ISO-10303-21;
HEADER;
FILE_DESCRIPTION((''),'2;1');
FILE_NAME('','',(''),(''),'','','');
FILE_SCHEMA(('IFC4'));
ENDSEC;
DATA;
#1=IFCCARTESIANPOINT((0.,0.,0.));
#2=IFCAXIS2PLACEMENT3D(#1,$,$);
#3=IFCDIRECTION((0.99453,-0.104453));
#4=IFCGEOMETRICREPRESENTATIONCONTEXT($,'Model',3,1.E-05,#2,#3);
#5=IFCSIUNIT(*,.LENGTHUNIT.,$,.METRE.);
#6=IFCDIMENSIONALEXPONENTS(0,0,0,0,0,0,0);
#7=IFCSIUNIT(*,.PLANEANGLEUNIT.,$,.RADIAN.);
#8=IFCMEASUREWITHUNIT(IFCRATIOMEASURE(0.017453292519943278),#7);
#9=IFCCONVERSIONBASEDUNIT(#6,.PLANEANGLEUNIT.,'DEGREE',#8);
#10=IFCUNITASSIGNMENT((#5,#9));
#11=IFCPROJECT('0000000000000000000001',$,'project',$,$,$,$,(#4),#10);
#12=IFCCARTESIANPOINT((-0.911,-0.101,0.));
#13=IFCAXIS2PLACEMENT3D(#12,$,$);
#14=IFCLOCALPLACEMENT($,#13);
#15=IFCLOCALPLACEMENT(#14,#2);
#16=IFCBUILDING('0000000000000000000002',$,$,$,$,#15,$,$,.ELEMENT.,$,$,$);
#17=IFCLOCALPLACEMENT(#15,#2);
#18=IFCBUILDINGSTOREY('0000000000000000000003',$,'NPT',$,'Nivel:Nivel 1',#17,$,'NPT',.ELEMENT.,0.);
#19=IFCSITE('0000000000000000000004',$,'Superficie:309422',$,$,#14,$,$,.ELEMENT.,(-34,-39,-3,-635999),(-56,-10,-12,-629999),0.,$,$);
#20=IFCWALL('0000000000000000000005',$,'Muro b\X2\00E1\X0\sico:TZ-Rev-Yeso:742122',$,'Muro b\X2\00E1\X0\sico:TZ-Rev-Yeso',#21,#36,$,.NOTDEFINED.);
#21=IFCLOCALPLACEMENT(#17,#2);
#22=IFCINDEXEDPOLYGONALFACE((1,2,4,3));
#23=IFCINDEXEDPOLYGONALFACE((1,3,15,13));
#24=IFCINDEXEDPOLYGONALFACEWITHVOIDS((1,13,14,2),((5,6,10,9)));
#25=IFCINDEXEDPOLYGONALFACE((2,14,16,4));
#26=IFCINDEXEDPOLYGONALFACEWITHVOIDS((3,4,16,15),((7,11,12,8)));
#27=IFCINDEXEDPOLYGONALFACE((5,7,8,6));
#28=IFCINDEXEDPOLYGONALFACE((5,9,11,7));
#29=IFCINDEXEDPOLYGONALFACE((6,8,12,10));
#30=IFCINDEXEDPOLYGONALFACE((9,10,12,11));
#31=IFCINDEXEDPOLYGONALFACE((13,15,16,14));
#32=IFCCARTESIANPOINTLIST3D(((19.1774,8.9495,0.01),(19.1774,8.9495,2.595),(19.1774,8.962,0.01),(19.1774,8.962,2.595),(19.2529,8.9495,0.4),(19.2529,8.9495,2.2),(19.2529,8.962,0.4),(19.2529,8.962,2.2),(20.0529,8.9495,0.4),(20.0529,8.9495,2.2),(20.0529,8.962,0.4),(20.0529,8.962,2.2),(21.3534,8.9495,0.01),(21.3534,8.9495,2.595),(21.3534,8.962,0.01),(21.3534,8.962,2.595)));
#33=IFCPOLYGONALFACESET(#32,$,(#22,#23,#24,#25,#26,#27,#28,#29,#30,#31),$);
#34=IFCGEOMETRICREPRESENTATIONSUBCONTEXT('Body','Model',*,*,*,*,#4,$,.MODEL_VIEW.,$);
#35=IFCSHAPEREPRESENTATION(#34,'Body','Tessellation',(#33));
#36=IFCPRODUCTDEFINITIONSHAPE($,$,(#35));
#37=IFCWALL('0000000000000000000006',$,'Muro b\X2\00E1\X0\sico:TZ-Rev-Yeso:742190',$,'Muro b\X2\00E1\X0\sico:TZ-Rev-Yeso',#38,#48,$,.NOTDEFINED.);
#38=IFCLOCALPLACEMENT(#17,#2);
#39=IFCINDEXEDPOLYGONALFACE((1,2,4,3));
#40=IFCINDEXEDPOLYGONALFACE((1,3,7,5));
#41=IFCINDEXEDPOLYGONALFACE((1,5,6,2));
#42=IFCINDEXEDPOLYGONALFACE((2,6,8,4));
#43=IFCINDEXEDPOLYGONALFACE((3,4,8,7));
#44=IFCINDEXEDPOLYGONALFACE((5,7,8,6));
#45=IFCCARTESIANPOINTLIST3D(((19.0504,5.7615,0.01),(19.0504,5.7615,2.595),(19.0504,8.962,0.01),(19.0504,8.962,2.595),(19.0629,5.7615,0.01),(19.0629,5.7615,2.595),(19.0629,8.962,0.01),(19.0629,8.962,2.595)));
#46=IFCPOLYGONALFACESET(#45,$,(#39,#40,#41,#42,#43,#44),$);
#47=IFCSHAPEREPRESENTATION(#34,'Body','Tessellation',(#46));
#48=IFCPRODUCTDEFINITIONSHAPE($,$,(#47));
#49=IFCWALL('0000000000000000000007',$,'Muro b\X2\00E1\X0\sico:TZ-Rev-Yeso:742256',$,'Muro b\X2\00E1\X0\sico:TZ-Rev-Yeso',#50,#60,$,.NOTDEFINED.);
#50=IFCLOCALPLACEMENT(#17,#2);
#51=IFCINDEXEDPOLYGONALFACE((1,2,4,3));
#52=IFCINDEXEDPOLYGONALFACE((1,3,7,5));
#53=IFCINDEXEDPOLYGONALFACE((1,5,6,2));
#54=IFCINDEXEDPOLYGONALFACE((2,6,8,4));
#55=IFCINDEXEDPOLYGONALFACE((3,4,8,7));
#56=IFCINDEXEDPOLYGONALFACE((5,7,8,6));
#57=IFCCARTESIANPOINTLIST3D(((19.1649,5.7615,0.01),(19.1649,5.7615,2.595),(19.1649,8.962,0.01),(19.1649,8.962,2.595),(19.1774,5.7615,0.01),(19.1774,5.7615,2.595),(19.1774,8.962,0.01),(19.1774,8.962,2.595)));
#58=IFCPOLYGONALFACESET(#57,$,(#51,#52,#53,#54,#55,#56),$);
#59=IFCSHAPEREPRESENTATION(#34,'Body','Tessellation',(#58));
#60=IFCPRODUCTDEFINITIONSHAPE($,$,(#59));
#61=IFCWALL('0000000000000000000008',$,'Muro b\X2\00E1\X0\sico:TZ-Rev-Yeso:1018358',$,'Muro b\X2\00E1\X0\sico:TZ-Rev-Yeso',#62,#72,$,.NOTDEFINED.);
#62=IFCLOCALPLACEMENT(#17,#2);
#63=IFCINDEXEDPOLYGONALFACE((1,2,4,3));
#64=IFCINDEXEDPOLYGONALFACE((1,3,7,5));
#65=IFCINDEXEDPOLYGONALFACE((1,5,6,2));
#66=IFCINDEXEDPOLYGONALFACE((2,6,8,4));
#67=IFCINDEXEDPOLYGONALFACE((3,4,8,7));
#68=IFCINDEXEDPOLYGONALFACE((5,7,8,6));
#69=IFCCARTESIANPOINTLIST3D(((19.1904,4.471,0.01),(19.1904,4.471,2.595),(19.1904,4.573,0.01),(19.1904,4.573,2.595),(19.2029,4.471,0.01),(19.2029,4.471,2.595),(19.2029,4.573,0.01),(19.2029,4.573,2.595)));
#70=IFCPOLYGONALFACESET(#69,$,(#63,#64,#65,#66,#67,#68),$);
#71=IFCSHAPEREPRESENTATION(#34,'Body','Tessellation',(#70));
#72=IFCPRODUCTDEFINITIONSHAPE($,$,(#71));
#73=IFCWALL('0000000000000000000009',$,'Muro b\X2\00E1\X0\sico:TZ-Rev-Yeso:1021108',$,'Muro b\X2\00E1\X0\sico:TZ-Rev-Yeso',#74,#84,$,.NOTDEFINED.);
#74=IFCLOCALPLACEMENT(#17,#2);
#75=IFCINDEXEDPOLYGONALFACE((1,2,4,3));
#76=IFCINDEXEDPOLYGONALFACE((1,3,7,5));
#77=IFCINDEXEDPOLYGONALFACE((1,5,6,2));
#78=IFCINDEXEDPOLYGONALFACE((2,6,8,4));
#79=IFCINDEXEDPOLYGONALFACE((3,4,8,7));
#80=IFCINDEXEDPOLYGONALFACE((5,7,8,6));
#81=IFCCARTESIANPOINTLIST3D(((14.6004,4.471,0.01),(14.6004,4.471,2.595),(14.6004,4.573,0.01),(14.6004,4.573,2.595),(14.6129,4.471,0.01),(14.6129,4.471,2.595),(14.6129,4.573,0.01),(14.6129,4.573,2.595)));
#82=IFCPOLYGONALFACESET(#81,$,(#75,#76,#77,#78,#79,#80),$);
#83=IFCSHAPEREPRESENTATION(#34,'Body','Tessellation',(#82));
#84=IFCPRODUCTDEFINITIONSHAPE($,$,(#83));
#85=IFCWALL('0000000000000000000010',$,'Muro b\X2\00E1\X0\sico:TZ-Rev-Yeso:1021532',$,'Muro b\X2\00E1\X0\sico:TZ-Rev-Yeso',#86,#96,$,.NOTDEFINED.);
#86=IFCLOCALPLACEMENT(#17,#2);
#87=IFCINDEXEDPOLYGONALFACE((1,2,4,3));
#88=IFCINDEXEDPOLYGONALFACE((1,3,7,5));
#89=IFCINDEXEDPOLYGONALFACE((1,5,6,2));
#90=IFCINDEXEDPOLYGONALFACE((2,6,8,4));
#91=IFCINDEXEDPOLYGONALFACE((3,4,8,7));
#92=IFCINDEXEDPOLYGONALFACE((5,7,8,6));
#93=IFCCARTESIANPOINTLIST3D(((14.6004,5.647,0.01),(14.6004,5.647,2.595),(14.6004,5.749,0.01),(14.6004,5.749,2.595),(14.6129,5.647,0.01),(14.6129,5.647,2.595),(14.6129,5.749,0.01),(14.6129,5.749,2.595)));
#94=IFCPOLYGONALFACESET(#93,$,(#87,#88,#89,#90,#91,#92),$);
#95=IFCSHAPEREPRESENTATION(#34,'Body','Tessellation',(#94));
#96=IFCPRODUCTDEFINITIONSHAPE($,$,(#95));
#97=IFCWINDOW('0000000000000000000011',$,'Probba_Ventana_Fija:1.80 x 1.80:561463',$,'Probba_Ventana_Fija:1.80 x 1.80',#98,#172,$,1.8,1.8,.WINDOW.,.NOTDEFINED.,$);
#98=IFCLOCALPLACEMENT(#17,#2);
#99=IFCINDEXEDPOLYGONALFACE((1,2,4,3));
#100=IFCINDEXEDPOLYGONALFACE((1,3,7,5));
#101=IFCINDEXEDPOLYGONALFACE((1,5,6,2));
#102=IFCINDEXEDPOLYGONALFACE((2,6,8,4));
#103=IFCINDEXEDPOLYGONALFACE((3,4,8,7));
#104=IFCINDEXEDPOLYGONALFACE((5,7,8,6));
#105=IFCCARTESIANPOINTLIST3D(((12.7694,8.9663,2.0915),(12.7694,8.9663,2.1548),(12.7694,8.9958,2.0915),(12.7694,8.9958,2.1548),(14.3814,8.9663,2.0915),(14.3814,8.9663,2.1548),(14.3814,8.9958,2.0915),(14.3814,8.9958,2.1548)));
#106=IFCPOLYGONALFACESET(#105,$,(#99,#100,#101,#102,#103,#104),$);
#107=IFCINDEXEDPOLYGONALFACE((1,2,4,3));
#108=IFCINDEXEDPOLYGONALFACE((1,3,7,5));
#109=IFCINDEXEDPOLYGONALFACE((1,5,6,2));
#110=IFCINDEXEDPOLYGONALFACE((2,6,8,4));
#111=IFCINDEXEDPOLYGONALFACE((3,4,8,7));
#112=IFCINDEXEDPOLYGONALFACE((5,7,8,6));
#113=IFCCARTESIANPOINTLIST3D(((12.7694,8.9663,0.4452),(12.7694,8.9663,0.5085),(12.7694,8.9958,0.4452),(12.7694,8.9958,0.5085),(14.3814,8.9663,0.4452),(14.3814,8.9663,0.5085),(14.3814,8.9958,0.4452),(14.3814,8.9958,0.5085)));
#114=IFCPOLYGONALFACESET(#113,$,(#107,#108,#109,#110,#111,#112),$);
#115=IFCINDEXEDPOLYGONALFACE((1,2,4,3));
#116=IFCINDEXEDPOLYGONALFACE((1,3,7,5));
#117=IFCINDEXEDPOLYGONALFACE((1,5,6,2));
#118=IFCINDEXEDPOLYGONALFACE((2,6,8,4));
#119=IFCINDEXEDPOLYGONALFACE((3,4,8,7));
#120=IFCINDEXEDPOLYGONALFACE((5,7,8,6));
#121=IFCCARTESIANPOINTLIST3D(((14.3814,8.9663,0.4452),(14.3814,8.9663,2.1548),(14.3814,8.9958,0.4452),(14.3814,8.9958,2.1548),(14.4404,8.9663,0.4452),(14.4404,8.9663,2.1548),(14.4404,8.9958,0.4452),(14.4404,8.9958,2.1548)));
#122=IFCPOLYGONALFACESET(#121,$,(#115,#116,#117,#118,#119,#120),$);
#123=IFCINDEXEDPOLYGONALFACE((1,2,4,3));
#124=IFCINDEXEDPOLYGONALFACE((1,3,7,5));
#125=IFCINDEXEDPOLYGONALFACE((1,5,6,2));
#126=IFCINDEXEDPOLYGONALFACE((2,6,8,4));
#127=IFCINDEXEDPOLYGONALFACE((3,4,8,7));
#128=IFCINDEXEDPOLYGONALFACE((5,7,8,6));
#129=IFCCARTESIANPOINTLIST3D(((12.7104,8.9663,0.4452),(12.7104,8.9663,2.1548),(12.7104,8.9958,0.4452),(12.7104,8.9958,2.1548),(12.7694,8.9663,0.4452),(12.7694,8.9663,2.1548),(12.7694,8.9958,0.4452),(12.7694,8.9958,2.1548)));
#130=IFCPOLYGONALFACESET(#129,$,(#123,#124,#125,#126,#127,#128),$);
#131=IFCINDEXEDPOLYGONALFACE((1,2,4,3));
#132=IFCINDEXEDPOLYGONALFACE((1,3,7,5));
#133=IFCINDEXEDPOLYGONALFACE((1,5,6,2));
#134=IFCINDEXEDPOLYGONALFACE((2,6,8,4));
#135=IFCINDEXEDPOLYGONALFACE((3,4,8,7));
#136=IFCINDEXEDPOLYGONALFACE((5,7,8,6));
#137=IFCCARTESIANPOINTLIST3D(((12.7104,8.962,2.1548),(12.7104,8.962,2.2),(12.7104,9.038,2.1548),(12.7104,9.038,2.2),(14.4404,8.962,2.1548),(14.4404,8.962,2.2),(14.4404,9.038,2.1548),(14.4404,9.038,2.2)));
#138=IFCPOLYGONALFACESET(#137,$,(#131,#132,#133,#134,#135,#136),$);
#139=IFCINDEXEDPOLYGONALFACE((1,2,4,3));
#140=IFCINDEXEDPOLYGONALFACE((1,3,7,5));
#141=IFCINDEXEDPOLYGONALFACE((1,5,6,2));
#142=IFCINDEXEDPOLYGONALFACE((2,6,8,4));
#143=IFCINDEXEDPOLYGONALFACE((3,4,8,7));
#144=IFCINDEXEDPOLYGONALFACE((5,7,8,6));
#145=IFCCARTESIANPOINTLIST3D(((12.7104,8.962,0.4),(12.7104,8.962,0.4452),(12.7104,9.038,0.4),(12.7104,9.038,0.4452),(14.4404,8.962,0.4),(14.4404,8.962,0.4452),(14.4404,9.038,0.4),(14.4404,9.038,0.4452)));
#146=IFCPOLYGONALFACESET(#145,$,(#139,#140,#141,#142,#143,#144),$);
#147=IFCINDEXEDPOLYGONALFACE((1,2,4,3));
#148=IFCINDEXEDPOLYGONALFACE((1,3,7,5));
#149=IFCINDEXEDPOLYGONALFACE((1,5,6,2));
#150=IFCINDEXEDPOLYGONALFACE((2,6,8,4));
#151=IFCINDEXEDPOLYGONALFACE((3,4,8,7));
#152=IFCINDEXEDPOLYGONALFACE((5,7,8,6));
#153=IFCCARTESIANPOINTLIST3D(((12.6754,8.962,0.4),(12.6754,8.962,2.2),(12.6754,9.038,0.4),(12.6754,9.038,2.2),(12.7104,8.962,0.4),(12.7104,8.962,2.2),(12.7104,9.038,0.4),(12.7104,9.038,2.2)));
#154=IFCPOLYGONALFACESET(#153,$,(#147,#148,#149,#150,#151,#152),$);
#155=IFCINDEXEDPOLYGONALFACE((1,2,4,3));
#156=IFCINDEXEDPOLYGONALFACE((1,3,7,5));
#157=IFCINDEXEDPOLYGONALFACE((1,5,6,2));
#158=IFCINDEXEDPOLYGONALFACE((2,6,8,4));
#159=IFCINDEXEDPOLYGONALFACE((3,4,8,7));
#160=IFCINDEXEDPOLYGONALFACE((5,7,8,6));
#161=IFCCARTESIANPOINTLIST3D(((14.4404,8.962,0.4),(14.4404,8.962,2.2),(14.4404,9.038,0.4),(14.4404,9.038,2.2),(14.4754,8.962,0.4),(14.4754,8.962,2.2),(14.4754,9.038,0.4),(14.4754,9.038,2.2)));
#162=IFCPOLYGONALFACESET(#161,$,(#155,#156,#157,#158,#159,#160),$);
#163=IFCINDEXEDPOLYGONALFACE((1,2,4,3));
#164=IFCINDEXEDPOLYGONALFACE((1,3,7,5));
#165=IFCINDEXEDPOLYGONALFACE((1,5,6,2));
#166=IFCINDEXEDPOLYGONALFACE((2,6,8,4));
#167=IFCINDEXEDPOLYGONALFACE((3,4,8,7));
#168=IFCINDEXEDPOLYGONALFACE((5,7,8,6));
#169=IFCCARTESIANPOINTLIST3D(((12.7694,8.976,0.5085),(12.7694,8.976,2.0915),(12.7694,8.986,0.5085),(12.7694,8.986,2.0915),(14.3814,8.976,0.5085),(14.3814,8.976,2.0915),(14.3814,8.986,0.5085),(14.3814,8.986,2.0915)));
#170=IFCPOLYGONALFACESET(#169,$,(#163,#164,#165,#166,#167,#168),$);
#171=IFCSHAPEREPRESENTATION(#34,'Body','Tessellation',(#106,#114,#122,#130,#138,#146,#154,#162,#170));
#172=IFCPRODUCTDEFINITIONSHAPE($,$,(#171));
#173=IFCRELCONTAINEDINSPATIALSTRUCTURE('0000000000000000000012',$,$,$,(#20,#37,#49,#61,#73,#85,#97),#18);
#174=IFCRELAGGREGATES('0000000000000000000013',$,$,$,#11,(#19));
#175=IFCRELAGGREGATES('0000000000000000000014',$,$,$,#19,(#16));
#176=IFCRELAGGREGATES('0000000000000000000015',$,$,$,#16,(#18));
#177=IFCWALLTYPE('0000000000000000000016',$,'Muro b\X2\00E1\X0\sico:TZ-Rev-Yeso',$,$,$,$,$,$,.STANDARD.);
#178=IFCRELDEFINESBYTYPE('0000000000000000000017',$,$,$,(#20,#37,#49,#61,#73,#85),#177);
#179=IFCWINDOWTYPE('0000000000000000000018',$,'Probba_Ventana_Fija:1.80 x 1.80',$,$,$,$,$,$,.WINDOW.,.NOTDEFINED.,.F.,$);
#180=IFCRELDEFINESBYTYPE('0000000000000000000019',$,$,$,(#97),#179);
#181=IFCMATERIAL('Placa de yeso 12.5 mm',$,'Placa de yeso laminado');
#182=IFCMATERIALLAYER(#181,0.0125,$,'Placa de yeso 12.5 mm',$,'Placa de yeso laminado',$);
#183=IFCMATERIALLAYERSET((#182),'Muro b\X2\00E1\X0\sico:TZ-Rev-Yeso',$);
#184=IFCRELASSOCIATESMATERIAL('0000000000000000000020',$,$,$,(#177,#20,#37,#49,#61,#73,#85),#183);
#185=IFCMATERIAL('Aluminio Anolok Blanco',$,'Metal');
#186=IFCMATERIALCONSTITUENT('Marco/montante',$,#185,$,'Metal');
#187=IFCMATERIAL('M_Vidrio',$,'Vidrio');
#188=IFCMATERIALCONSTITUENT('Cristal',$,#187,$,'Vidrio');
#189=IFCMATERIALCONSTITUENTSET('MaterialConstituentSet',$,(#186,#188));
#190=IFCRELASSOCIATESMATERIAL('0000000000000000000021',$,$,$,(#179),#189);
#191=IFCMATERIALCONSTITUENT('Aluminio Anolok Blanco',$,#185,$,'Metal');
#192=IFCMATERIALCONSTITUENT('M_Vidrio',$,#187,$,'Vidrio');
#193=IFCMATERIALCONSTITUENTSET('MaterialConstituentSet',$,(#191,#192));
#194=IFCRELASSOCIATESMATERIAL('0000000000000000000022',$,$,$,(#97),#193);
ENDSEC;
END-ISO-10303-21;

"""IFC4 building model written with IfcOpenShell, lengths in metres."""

from ifc_helpers import new_model, entity, si_unit, converted_unit, direction, frame, frame_2d, origin, origin_2d_with_axis, place, context, subcontext, project, spatial, rectangle, extrude, source, transform, mapped, material, layer, layer_set, layer_usage, constituent, constituent_set, type_object, type_shapes, element, save


model = new_model("IFC4")

# Units and contexts
model_context = context("Model", 3, precision=1e-05, world=origin(), true_north=direction((0.99453, -0.104453)))
body_context = subcontext(model_context, "Body", "Model", "MODEL_VIEW")
ifc_project = project(units=[si_unit("LENGTHUNIT", "METRE"), converted_unit("PLANEANGLEUNIT", "DEGREE", entity("IfcRatioMeasure", 0.017453292519943278), si_unit("PLANEANGLEUNIT", "RADIAN"), dimensions=[0, 0, 0, 0, 0, 0, 0])], contexts=[model_context])

# Site, building, storey
site_placement = place(None, frame((-0.911, -0.101, 0.0)))
site = spatial("IfcSite", under=ifc_project, at=site_placement, Name="Superficie:309422", CompositionType="ELEMENT", RefLatitude=(-34, -39, -3, -635999), RefLongitude=(-56, -10, -12, -629999), RefElevation=0.0)
building_placement = place(site_placement, origin())
building = spatial("IfcBuilding", under=site, at=building_placement, CompositionType="ELEMENT")
storey_placement = place(building_placement, origin())
storey = spatial("IfcBuildingStorey", under=building, at=storey_placement, Name="NPT", ObjectType="Nivel:Nivel 1", LongName="NPT", CompositionType="ELEMENT", Elevation=0.0)

# Shared definitions
ifc_material_1 = material(Name="Placa de yeso 12.5 mm", Category="Placa de yeso laminado")
ifc_layer_1 = layer(ifc_material_1, 0.0125, Name="Placa de yeso 12.5 mm", Category="Placa de yeso laminado")
ifc_layer_set_1 = layer_set([ifc_layer_1], Name="Muro básico:TZ-Rev-Yeso")
wall_type_1 = type_object("IfcWallType", Name="Muro básico:TZ-Rev-Yeso", PredefinedType="STANDARD", material=ifc_layer_set_1)

# Wall, opening
ifc_layer_usage_1 = layer_usage(ifc_layer_set_1, "AXIS2", "NEGATIVE", 0.0063)
wall_1_placement = place(storey_placement, frame((19.1774, 8.9558, 0.01)))
wall_1 = element("IfcWall", 1, at=wall_1_placement, inside=storey, type_object=wall_type_1, material=ifc_layer_usage_1, Name="Muro básico:TZ-Rev-Yeso:742122", ObjectType="Muro básico:TZ-Rev-Yeso", PredefinedType="NOTDEFINED", context=body_context, shape_type="SweptSolid", body=[
    extrude(rectangle(XDim=2.176, YDim=0.0125, at=frame_2d((1.088, 0.0), x_axis=(-1.0, 0.0))), origin(), (0.0, 0.0, 1.0), 2.585),
])
opening_1_placement = place(wall_1_placement, frame((0.0755, -1.5178, 0.39)))
element("IfcOpeningElement", 2, at=opening_1_placement, cuts=wall_1, PredefinedType="OPENING", context=body_context, shape_type="SweptSolid", body=[
    extrude(rectangle(XDim=1.8, YDim=0.8, at=frame_2d((0.0, 0.0), x_axis=(1.0, 0.0))), frame((0.4, 0.0, 0.9), z_axis=(0.0, 1.0, 0.0), x_axis=(0.0, 0.0, 1.0)), (0.0, 0.0, 1.0), 3.048),
])

# Walls
ifc_layer_usage_2 = layer_usage(ifc_layer_set_1, "AXIS2", "POSITIVE", -0.0063)
wall_2_placement = place(storey_placement, frame((19.0567, 5.7615, 0.01), z_axis=(0.0, 0.0, 1.0), x_axis=(0.0, 1.0, 0.0)))
element("IfcWall", 3, at=wall_2_placement, inside=storey, type_object=wall_type_1, material=ifc_layer_usage_2, Name="Muro básico:TZ-Rev-Yeso:742190", ObjectType="Muro básico:TZ-Rev-Yeso", PredefinedType="NOTDEFINED", context=body_context, shape_type="SweptSolid", body=[
    extrude(rectangle(XDim=3.2005, YDim=0.0125, at=frame_2d((1.6003, 0.0), x_axis=(-1.0, 0.0))), origin(), (0.0, 0.0, 1.0), 2.585),
])
ifc_layer_usage_3 = layer_usage(ifc_layer_set_1, "AXIS2", "POSITIVE", -0.0063)
wall_3_placement = place(storey_placement, frame((19.1712, 8.962, 0.01), z_axis=(0.0, 0.0, 1.0), x_axis=(0.0, -1.0, 0.0)))
element("IfcWall", 4, at=wall_3_placement, inside=storey, type_object=wall_type_1, material=ifc_layer_usage_3, Name="Muro básico:TZ-Rev-Yeso:742256", ObjectType="Muro básico:TZ-Rev-Yeso", PredefinedType="NOTDEFINED", context=body_context, shape_type="SweptSolid", body=[
    extrude(rectangle(XDim=3.2005, YDim=0.0125, at=frame_2d((1.6003, 0.0), x_axis=(-1.0, 0.0))), origin(), (0.0, 0.0, 1.0), 2.585),
])

# Walls
ifc_layer_usage_4 = layer_usage(ifc_layer_set_1, "AXIS2", "POSITIVE", -0.0063)
wall_4_placement = place(storey_placement, frame((19.1967, 4.573, 0.01), z_axis=(0.0, 0.0, 1.0), x_axis=(0.0, -1.0, 0.0)))
element("IfcWall", 5, at=wall_4_placement, inside=storey, type_object=wall_type_1, material=ifc_layer_usage_4, Name="Muro básico:TZ-Rev-Yeso:1018358", ObjectType="Muro básico:TZ-Rev-Yeso", PredefinedType="NOTDEFINED", context=body_context, shape_type="SweptSolid", body=[
    extrude(rectangle(XDim=0.102, YDim=0.0125, at=frame_2d((0.051, 0.0), x_axis=(-1.0, 0.0))), origin(), (0.0, 0.0, 1.0), 2.585),
])
ifc_layer_usage_5 = layer_usage(ifc_layer_set_1, "AXIS2", "POSITIVE", -0.0063)
wall_5_placement = place(storey_placement, frame((14.6067, 4.573, 0.01), z_axis=(0.0, 0.0, 1.0), x_axis=(0.0, -1.0, 0.0)))
element("IfcWall", 6, at=wall_5_placement, inside=storey, type_object=wall_type_1, material=ifc_layer_usage_5, Name="Muro básico:TZ-Rev-Yeso:1021108", ObjectType="Muro básico:TZ-Rev-Yeso", PredefinedType="NOTDEFINED", context=body_context, shape_type="SweptSolid", body=[
    extrude(rectangle(XDim=0.102, YDim=0.0125, at=frame_2d((0.051, 0.0), x_axis=(-1.0, 0.0))), origin(), (0.0, 0.0, 1.0), 2.585),
])
ifc_layer_usage_6 = layer_usage(ifc_layer_set_1, "AXIS2", "NEGATIVE", 0.0063)
wall_6_placement = place(storey_placement, frame((14.6067, 5.647, 0.01), z_axis=(0.0, 0.0, 1.0), x_axis=(0.0, 1.0, 0.0)))
element("IfcWall", 7, at=wall_6_placement, inside=storey, type_object=wall_type_1, material=ifc_layer_usage_6, Name="Muro básico:TZ-Rev-Yeso:1021532", ObjectType="Muro básico:TZ-Rev-Yeso", PredefinedType="NOTDEFINED", context=body_context, shape_type="SweptSolid", body=[
    extrude(rectangle(XDim=0.102, YDim=0.0125, at=frame_2d((0.051, 0.0), x_axis=(-1.0, 0.0))), origin(), (0.0, 0.0, 1.0), 2.585),
])

# Window
ifc_material_2 = material(Name="Aluminio Anolok Blanco", Category="Metal")
ifc_constituent_1 = constituent(ifc_material_2, Name="Aluminio Anolok Blanco", Category="Metal")
ifc_material_3 = material(Name="M_Vidrio", Category="Vidrio")
ifc_constituent_2 = constituent(ifc_material_3, Name="M_Vidrio", Category="Vidrio")
ifc_constituent_set_1 = constituent_set(constituents=[ifc_constituent_1, ifc_constituent_2], Name="MaterialConstituentSet")
ifc_constituent_3 = constituent(ifc_material_2, Name="Marco/montante", Category="Metal")
ifc_constituent_4 = constituent(ifc_material_3, Name="Cristal", Category="Vidrio")
ifc_constituent_set_2 = constituent_set(constituents=[ifc_constituent_3, ifc_constituent_4], Name="MaterialConstituentSet")
window_type = type_object("IfcWindowType", Name="Probba_Ventana_Fija:1.80 x 1.80", ParameterTakesPrecedence=False, PartitioningType="NOTDEFINED", PredefinedType="WINDOW", material=ifc_constituent_set_2)
shared_shape_1 = source(origin(), body_context, "Body", "SweptSolid", [
    extrude(rectangle(XDim=1.612, YDim=0.0295, at=origin_2d_with_axis()), frame((0.9, 0.019, 1.6915)), (0.0, 0.0, 1.0), 0.0633),
    extrude(rectangle(XDim=1.612, YDim=0.0295, at=origin_2d_with_axis()), frame((0.9, 0.019, 0.0452)), (0.0, 0.0, 1.0), 0.0633),
    extrude(rectangle(XDim=0.0295, YDim=0.059, at=origin_2d_with_axis()), frame((1.7355, 0.019, 0.0452), z_axis=(0.0, 0.0, 1.0), x_axis=(0.0, 1.0, 0.0)), (0.0, 0.0, 1.0), 1.7096),
    extrude(rectangle(XDim=0.0295, YDim=0.059, at=origin_2d_with_axis()), frame((0.0645, 0.019, 0.0452), z_axis=(0.0, 0.0, 1.0), x_axis=(0.0, 1.0, 0.0)), (0.0, 0.0, 1.0), 1.7096),
    extrude(rectangle(XDim=1.73, YDim=0.076, at=origin_2d_with_axis()), frame((0.9, 0.038, 1.7548)), (0.0, 0.0, 1.0), 0.0452),
    extrude(rectangle(XDim=1.73, YDim=0.076, at=frame_2d((0.0, 0.0), x_axis=(1.0, 0.0))), frame((0.9, 0.038, 0.0)), (0.0, 0.0, 1.0), 0.0452),
    extrude(rectangle(XDim=0.035, YDim=0.076, at=origin_2d_with_axis()), frame((0.0175, 0.038, 0.0), z_axis=(0.0, 0.0, 1.0), x_axis=(-1.0, 0.0, 0.0)), (0.0, 0.0, 1.0), 1.8),
    extrude(rectangle(XDim=0.035, YDim=0.076, at=origin_2d_with_axis()), frame((1.7825, 0.038, 0.0), z_axis=(0.0, 0.0, 1.0), x_axis=(-1.0, 0.0, 0.0)), (0.0, 0.0, 1.0), 1.8),
    extrude(rectangle(XDim=0.01, YDim=1.612, at=frame_2d((0.0, 0.0), x_axis=(1.0, 0.0))), frame((0.9, 0.019, 0.1085), z_axis=(0.0, 0.0, 1.0), x_axis=(0.0, 1.0, 0.0)), (0.0, 0.0, 1.0), 1.583),
])
type_shapes(window_type, [shared_shape_1])
window_placement = place(storey_placement, frame((12.6754, 8.962, 0.4)))
element("IfcWindow", 8, at=window_placement, inside=storey, type_object=window_type, material=ifc_constituent_set_1, Name="Probba_Ventana_Fija:1.80 x 1.80:561463", ObjectType="Probba_Ventana_Fija:1.80 x 1.80", OverallHeight=1.8, OverallWidth=1.8, PartitioningType="NOTDEFINED", PredefinedType="WINDOW", context=body_context, shape_type="MappedRepresentation", body=[
    mapped(shared_shape_1, transform((0.0, 0.0, 0.0), scale=1.0)),
])

save(model, "model.ifc")
